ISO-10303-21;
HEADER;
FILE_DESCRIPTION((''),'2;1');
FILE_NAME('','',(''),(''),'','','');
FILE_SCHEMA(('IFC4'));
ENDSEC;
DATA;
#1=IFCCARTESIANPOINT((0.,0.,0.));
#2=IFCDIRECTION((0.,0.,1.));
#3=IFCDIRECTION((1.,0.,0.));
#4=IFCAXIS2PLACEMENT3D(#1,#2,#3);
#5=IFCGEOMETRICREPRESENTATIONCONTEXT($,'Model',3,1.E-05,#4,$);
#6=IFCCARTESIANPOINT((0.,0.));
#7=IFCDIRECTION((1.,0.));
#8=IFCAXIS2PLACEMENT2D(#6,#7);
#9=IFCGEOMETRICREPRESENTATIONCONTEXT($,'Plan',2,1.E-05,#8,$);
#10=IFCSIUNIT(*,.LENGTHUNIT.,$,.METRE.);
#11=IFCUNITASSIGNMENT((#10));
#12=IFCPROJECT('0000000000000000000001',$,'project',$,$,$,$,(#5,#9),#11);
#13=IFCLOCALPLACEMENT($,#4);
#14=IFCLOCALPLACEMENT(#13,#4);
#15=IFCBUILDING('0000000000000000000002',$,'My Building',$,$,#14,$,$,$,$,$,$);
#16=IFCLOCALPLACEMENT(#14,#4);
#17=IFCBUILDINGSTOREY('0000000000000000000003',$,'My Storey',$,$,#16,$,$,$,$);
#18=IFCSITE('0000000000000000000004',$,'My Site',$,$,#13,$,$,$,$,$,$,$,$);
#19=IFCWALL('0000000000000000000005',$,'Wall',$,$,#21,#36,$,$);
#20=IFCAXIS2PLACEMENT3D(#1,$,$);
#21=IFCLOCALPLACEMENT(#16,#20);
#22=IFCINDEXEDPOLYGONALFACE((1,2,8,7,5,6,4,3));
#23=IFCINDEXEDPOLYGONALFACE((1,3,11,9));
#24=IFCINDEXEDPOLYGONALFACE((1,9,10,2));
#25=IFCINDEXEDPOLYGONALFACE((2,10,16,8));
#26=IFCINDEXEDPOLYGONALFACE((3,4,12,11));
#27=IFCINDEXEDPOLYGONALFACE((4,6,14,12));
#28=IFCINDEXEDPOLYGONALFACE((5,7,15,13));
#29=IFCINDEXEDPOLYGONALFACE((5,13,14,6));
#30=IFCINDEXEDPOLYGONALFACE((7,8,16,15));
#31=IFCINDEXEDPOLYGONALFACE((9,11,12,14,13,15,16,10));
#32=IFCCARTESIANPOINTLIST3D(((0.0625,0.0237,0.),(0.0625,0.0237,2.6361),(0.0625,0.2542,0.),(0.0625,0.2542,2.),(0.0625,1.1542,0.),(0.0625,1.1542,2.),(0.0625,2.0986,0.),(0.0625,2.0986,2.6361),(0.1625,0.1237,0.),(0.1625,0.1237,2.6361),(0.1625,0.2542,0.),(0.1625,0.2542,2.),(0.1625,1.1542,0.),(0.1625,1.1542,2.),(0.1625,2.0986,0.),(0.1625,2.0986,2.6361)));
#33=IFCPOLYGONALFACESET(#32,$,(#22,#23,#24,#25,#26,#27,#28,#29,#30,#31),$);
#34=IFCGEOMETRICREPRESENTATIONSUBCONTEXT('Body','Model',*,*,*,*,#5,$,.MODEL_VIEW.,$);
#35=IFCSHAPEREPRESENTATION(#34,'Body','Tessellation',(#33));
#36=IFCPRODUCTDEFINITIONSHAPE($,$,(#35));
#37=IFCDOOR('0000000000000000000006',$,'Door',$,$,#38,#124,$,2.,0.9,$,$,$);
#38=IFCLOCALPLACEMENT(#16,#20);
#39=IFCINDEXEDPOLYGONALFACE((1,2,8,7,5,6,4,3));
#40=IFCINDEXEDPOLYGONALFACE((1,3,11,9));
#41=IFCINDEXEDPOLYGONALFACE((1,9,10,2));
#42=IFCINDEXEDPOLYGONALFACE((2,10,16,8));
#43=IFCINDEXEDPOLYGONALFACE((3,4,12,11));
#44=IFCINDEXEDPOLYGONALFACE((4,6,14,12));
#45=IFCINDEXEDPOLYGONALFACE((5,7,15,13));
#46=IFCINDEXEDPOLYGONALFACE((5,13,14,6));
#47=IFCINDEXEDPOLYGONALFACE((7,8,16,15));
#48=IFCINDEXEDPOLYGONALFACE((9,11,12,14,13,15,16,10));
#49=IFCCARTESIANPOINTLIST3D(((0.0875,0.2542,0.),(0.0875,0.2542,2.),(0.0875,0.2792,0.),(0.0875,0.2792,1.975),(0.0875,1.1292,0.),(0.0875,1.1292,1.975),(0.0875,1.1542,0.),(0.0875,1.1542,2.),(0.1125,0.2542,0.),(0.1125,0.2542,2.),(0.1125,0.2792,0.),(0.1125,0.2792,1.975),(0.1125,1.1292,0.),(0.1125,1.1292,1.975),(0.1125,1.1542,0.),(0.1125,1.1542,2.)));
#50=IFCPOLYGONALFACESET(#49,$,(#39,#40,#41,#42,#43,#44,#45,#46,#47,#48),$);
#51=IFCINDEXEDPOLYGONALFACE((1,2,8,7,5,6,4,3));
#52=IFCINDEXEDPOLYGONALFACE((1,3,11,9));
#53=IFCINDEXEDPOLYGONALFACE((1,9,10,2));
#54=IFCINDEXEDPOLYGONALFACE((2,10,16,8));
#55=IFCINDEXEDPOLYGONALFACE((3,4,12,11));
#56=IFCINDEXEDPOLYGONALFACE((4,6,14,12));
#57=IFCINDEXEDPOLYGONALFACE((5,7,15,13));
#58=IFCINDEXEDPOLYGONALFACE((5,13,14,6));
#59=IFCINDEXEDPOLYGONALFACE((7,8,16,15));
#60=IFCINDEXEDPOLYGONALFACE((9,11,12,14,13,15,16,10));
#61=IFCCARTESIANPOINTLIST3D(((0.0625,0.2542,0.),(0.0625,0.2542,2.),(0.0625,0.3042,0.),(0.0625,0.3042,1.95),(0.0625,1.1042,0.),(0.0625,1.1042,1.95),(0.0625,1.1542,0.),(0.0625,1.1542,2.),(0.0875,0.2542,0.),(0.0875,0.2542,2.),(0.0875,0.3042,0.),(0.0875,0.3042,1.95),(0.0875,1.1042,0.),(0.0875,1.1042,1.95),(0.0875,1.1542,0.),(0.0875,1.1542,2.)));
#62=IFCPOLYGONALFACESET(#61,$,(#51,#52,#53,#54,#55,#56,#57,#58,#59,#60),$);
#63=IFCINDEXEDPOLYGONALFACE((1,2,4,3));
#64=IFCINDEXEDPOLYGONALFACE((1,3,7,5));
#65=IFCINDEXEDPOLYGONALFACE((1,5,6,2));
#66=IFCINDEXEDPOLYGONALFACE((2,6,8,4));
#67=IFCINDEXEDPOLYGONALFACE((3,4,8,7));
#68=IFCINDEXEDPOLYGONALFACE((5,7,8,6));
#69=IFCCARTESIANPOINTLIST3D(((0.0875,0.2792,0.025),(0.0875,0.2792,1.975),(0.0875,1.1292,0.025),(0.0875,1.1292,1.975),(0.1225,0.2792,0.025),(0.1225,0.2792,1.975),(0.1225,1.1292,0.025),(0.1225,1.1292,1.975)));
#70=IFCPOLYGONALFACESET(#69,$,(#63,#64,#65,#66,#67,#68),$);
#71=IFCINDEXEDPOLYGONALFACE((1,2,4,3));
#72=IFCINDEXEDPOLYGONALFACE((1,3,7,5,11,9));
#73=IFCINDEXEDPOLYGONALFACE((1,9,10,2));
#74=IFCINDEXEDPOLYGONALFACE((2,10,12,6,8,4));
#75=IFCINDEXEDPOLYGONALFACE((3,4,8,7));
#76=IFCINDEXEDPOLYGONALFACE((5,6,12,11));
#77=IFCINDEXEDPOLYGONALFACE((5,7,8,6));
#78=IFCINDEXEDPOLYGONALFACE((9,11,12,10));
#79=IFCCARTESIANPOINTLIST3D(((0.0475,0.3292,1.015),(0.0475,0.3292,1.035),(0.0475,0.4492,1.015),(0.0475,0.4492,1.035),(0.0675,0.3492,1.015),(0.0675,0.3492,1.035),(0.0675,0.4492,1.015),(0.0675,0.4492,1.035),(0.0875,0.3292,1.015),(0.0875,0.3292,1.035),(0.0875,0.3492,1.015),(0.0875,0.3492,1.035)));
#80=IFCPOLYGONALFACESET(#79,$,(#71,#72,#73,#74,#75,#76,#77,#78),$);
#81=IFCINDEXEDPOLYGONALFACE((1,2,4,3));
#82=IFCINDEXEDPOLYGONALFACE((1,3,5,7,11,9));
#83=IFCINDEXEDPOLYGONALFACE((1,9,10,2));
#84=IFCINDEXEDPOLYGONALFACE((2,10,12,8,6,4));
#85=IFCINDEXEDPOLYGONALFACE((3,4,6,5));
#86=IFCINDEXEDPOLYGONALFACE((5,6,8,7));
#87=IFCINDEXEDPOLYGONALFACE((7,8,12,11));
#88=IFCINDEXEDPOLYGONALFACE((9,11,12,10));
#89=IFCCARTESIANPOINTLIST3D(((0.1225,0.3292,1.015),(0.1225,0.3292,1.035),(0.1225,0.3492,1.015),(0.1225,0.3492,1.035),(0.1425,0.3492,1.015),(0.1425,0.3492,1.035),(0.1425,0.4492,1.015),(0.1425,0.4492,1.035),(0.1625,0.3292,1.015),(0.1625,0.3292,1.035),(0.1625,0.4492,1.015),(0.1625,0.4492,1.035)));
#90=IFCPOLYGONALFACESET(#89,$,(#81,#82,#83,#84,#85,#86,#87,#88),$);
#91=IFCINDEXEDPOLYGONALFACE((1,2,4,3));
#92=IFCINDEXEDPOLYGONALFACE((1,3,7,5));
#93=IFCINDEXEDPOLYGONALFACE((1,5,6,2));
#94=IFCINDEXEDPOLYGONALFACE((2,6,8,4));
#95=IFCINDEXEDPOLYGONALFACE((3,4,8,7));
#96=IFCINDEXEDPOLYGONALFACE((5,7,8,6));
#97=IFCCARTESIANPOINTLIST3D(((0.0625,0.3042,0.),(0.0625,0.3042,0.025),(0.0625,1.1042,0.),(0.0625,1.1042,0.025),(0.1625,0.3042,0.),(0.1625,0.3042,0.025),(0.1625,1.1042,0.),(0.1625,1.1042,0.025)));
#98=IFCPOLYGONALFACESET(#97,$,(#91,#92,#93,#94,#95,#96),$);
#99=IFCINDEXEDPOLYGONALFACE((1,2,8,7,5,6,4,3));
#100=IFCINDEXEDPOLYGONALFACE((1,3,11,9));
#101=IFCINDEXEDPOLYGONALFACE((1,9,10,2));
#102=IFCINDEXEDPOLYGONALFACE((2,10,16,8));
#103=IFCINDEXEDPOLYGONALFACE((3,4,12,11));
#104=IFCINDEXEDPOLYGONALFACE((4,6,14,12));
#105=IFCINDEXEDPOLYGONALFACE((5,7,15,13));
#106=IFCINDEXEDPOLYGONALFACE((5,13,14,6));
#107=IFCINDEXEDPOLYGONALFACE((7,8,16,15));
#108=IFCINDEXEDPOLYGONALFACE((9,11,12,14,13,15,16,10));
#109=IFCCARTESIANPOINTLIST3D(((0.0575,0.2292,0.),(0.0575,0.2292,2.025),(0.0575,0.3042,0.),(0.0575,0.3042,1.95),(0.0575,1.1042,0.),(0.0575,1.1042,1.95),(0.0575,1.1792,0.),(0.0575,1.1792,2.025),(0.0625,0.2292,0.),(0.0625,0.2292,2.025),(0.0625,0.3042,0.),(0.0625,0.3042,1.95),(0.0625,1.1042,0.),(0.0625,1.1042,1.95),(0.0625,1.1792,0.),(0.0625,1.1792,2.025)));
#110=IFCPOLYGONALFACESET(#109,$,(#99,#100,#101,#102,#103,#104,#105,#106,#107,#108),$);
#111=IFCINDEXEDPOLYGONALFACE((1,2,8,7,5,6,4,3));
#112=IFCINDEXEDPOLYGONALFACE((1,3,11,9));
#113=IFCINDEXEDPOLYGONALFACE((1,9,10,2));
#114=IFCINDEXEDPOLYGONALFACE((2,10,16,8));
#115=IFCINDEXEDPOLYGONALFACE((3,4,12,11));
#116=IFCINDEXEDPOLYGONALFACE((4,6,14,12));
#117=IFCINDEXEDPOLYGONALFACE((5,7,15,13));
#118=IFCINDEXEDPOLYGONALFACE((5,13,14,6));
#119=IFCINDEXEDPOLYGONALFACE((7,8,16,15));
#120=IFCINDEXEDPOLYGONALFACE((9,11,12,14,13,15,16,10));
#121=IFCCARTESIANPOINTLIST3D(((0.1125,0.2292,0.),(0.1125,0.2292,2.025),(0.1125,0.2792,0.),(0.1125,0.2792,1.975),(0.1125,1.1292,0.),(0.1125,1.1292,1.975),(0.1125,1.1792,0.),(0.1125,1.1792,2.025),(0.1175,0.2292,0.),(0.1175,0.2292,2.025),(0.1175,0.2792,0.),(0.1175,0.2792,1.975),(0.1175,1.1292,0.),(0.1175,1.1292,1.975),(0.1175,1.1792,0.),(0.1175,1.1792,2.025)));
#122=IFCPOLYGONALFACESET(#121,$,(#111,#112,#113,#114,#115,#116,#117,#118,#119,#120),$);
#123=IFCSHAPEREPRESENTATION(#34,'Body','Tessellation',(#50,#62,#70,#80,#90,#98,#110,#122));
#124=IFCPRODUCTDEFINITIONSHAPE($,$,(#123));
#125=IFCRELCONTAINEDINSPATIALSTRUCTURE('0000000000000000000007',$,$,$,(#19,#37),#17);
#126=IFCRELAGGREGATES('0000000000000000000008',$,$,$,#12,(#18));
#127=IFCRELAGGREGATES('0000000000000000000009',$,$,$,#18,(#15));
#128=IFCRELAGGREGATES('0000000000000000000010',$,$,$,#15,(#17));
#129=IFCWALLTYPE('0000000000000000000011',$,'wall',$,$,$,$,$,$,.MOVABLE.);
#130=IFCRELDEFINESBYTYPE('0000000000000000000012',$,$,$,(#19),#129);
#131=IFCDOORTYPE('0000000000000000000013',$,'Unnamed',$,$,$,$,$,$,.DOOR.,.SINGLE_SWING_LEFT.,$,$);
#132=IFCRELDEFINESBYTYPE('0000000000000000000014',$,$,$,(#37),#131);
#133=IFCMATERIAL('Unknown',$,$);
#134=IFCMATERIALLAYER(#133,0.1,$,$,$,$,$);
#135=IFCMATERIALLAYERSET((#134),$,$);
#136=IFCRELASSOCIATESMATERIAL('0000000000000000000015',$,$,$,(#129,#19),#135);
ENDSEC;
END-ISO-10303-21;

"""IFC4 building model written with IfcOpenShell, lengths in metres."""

from ifc_helpers import new_model, entity, si_unit, frame, origin_with_axes, origin_2d_with_axis, place, context, subcontext, project, spatial, line, indexed_curve, outline, extrude, shape, source, transform, mapped, material, layer, layer_set, layer_usage, type_object, type_shapes, element, fill, save


model = new_model("IFC4")

# Units and contexts
model_context = context("Model", 3, precision=1e-05, world=origin_with_axes())
plan_context = context("Plan", 2, precision=1e-05, world=origin_2d_with_axis())
body_context_1 = subcontext(model_context, "Body", "Model", "MODEL_VIEW")
body_context_2 = subcontext(plan_context, "Body", "Plan", "PLAN_VIEW")
ifc_project = project(units=[si_unit("LENGTHUNIT", "METRE")], contexts=[model_context, plan_context])

# Site, building, storey
site_placement = place(None, origin_with_axes())
site = spatial("IfcSite", under=ifc_project, at=site_placement, Name="My Site")
building_placement = place(site_placement, origin_with_axes())
building = spatial("IfcBuilding", under=site, at=building_placement, Name="My Building")
storey_placement = place(building_placement, origin_with_axes())
storey = spatial("IfcBuildingStorey", under=building, at=storey_placement, Name="My Storey")

# Shared definitions
ifc_material = material(Name="Unknown")

# Wall, opening, door
ifc_layer_1 = layer(ifc_material, 0.1)
ifc_layer_set_1 = layer_set([ifc_layer_1])
ifc_layer_usage_1 = layer_usage(ifc_layer_set_1, "AXIS2", "POSITIVE", 0.0)
wall_type_1 = type_object("IfcWallType", Name="wall", PredefinedType="MOVABLE", material=ifc_layer_set_1)
wall_1_placement = place(storey_placement, frame((0.0625, 2.0986, 0.0), z_axis=(0.0, 0.0, 1.0), x_axis=(0.0, -1.0, 0.0)))
wall_1 = element("IfcWall", 1, at=wall_1_placement, inside=storey, type_object=wall_type_1, material=ifc_layer_usage_1, Name="Wall", context=body_context_1, shape_type="SweptSolid", body=[
    extrude(outline(indexed_curve([(0.0, 0.0), (0.0, 0.1), (1.975, 0.1), (2.075, 0.0)], segments=[line(1, 2, 3, 4, 1)])), origin_with_axes(), (0.0, 0.0, 1.0), 2.6361),
])
shared_shape_1 = source(origin_with_axes(), body_context_1, "Body", "SweptSolid", [
    extrude(outline(indexed_curve([(0.0, 0.0), (0.9, 0.0), (0.9, 2.0), (0.0, 2.0)], segments=[line(1, 2, 3, 4, 1)])), frame((0.0, -0.6, 0.0), z_axis=(0.0, -1.0, 0.0), x_axis=(1.0, 0.0, 0.0)), (0.0, 0.0, -1.0), 1.2),
])
opening_1_placement = place(wall_1_placement, frame((0.9444, 0.0, 0.0), z_axis=(0.0, 0.0, 1.0), x_axis=(1.0, 0.0, 0.0)))
opening_1 = element("IfcOpeningElement", 2, at=opening_1_placement, cuts=wall_1, PredefinedType="OPENING", context=body_context_1, shape_type="MappedRepresentation", body=[
    mapped(shared_shape_1, transform((0.0, 0.0, 0.0), x_axis=(1.0, 0.0, 0.0), y_axis=(0.0, 1.0, 0.0), z_axis=(0.0, 0.0, 1.0), scale=1.0)),
])
door_type = type_object("IfcDoorType", Name="Unnamed", OperationType="SINGLE_SWING_LEFT", PredefinedType="DOOR")
shared_shape_2 = source(origin_with_axes(), body_context_1, "Body", "SweptSolid", [
    extrude(outline(indexed_curve([(0.0, 0.0), (0.0, 2.0), (0.9, 2.0), (0.9, 0.0), (0.875, 0.0), (0.875, 1.975), (0.025, 1.975), (0.025, 0.0)], segments=[line(1, 2, 3, 4, 5, 6, 7, 8, 1)])), frame((0.0, 0.025, 0.0), z_axis=(0.0, -1.0, 0.0), x_axis=(1.0, 0.0, 0.0)), (0.0, 0.0, -1.0), 0.025),
    extrude(outline(indexed_curve([(0.0, 0.0), (0.0, 2.0), (0.9, 2.0), (0.9, 0.0), (0.85, 0.0), (0.85, 1.95), (0.05, 1.95), (0.05, 0.0)], segments=[line(1, 2, 3, 4, 5, 6, 7, 8, 1)])), frame((0.0, 0.0, 0.0), z_axis=(0.0, -1.0, 0.0), x_axis=(1.0, 0.0, 0.0)), (0.0, 0.0, -1.0), 0.025),
    extrude(outline(indexed_curve([(0.0, 0.0), (0.85, 0.0), (0.85, 0.035), (0.0, 0.035)], segments=[line(1, 2, 3, 4, 1)])), frame((0.025, 0.025, 0.025), z_axis=(0.0, 0.0, 1.0), x_axis=(1.0, 0.0, 0.0)), (0.0, 0.0, 1.0), 1.95),
    extrude(outline(indexed_curve([(0.0, 0.0), (0.0, -0.04), (-0.12, -0.04), (-0.12, -0.02), (-0.02, -0.02), (-0.02, 0.0)], segments=[line(1, 2, 3, 4, 5, 6, 1)])), frame((0.825, 0.025, 1.015), z_axis=(0.0, 0.0, 1.0), x_axis=(1.0, 0.0, 0.0)), (0.0, 0.0, 1.0), 0.02),
    extrude(outline(indexed_curve([(0.0, 0.0), (0.0, 0.04), (-0.12, 0.04), (-0.12, 0.02), (-0.02, 0.02), (-0.02, 0.0)], segments=[line(1, 2, 3, 4, 5, 6, 1)])), frame((0.825, 0.06, 1.015), z_axis=(0.0, 0.0, 1.0), x_axis=(1.0, 0.0, 0.0)), (0.0, 0.0, 1.0), 0.02),
    extrude(outline(indexed_curve([(0.0, 0.0), (0.8, 0.0), (0.8, 0.1), (0.0, 0.1)], segments=[line(1, 2, 3, 4, 1)])), frame((0.05, 0.0, 0.0), z_axis=(0.0, 0.0, 1.0), x_axis=(1.0, 0.0, 0.0)), (0.0, 0.0, 1.0), 0.025),
    extrude(outline(indexed_curve([(0.0, 0.0), (0.0, 2.025), (0.95, 2.025), (0.95, 0.0), (0.875, 0.0), (0.875, 1.95), (0.075, 1.95), (0.075, 0.0)], segments=[line(1, 2, 3, 4, 5, 6, 7, 8, 1)])), frame((-0.025, -0.005, 0.0), z_axis=(0.0, -1.0, 0.0), x_axis=(1.0, 0.0, 0.0)), (0.0, 0.0, -1.0), 0.005),
    extrude(outline(indexed_curve([(0.0, 0.0), (0.0, 2.025), (0.95, 2.025), (0.95, 0.0), (0.9, 0.0), (0.9, 1.975), (0.05, 1.975), (0.05, 0.0)], segments=[line(1, 2, 3, 4, 5, 6, 7, 8, 1)])), frame((-0.025, 0.05, 0.0), z_axis=(0.0, -1.0, 0.0), x_axis=(1.0, 0.0, 0.0)), (0.0, 0.0, -1.0), 0.005),
])
shared_shape_3 = source(origin_with_axes(), body_context_2, "Body", "Curve2D", [
    entity("IfcIndexedPolyCurve", entity("IfcCartesianPointList2D", [[0.0, 0.0], [0.0, 0.05], [0.025, 0.05], [0.025, 0.025], [0.05, 0.025], [0.05, 0.0]]), [entity("IfcLineIndex", [1, 2, 3, 4, 5, 6, 1])]),
    entity("IfcIndexedPolyCurve", entity("IfcCartesianPointList2D", [[0.9, 0.0], [0.9, 0.05], [0.875, 0.05], [0.875, 0.025], [0.85, 0.025], [0.85, 0.0]]), [entity("IfcLineIndex", [1, 2, 3, 4, 5, 6, 1])]),
    entity("IfcTrimmedCurve", entity("IfcEllipse", entity("IfcAxis2Placement2D", entity("IfcCartesianPoint", [0.06, 0.05]), entity("IfcDirection", [1.0, 0.0])), 0.815, 0.85), [entity("IfcCartesianPoint", [0.875, 0.05])], [entity("IfcCartesianPoint", [0.06, 0.9])], True, "CARTESIAN"),
    entity("IfcIndexedPolyCurve", entity("IfcCartesianPointList2D", [[0.025, 0.05], [0.06, 0.05], [0.06, 0.9], [0.025, 0.9]]), [entity("IfcLineIndex", [1, 2, 3, 4, 1])]),
])
type_shapes(door_type, [shared_shape_2, shared_shape_3])
door_placement = place(opening_1_placement, frame((0.0, 0.0, 0.0), z_axis=(0.0, 0.0, 1.0), x_axis=(1.0, 0.0, 0.0)))
door = element("IfcDoor", 3, at=door_placement, inside=storey, type_object=door_type, Name="Door", OverallHeight=2.0, OverallWidth=0.9, shapes=[
    shape(body_context_1, "Body", "MappedRepresentation", [mapped(shared_shape_2, transform((0.0, 0.0, 0.0), x_axis=(1.0, 0.0, 0.0), y_axis=(0.0, 1.0, 0.0), z_axis=(0.0, 0.0, 1.0), scale=1.0))]),
    shape(body_context_2, "Body", "MappedRepresentation", [mapped(shared_shape_3, transform((0.0, 0.0, 0.0), x_axis=(1.0, 0.0, 0.0), y_axis=(0.0, 1.0, 0.0), z_axis=(0.0, 0.0, 1.0), scale=1.0))]),
])
fill(opening_1, door)

save(model, "model.ifc")
